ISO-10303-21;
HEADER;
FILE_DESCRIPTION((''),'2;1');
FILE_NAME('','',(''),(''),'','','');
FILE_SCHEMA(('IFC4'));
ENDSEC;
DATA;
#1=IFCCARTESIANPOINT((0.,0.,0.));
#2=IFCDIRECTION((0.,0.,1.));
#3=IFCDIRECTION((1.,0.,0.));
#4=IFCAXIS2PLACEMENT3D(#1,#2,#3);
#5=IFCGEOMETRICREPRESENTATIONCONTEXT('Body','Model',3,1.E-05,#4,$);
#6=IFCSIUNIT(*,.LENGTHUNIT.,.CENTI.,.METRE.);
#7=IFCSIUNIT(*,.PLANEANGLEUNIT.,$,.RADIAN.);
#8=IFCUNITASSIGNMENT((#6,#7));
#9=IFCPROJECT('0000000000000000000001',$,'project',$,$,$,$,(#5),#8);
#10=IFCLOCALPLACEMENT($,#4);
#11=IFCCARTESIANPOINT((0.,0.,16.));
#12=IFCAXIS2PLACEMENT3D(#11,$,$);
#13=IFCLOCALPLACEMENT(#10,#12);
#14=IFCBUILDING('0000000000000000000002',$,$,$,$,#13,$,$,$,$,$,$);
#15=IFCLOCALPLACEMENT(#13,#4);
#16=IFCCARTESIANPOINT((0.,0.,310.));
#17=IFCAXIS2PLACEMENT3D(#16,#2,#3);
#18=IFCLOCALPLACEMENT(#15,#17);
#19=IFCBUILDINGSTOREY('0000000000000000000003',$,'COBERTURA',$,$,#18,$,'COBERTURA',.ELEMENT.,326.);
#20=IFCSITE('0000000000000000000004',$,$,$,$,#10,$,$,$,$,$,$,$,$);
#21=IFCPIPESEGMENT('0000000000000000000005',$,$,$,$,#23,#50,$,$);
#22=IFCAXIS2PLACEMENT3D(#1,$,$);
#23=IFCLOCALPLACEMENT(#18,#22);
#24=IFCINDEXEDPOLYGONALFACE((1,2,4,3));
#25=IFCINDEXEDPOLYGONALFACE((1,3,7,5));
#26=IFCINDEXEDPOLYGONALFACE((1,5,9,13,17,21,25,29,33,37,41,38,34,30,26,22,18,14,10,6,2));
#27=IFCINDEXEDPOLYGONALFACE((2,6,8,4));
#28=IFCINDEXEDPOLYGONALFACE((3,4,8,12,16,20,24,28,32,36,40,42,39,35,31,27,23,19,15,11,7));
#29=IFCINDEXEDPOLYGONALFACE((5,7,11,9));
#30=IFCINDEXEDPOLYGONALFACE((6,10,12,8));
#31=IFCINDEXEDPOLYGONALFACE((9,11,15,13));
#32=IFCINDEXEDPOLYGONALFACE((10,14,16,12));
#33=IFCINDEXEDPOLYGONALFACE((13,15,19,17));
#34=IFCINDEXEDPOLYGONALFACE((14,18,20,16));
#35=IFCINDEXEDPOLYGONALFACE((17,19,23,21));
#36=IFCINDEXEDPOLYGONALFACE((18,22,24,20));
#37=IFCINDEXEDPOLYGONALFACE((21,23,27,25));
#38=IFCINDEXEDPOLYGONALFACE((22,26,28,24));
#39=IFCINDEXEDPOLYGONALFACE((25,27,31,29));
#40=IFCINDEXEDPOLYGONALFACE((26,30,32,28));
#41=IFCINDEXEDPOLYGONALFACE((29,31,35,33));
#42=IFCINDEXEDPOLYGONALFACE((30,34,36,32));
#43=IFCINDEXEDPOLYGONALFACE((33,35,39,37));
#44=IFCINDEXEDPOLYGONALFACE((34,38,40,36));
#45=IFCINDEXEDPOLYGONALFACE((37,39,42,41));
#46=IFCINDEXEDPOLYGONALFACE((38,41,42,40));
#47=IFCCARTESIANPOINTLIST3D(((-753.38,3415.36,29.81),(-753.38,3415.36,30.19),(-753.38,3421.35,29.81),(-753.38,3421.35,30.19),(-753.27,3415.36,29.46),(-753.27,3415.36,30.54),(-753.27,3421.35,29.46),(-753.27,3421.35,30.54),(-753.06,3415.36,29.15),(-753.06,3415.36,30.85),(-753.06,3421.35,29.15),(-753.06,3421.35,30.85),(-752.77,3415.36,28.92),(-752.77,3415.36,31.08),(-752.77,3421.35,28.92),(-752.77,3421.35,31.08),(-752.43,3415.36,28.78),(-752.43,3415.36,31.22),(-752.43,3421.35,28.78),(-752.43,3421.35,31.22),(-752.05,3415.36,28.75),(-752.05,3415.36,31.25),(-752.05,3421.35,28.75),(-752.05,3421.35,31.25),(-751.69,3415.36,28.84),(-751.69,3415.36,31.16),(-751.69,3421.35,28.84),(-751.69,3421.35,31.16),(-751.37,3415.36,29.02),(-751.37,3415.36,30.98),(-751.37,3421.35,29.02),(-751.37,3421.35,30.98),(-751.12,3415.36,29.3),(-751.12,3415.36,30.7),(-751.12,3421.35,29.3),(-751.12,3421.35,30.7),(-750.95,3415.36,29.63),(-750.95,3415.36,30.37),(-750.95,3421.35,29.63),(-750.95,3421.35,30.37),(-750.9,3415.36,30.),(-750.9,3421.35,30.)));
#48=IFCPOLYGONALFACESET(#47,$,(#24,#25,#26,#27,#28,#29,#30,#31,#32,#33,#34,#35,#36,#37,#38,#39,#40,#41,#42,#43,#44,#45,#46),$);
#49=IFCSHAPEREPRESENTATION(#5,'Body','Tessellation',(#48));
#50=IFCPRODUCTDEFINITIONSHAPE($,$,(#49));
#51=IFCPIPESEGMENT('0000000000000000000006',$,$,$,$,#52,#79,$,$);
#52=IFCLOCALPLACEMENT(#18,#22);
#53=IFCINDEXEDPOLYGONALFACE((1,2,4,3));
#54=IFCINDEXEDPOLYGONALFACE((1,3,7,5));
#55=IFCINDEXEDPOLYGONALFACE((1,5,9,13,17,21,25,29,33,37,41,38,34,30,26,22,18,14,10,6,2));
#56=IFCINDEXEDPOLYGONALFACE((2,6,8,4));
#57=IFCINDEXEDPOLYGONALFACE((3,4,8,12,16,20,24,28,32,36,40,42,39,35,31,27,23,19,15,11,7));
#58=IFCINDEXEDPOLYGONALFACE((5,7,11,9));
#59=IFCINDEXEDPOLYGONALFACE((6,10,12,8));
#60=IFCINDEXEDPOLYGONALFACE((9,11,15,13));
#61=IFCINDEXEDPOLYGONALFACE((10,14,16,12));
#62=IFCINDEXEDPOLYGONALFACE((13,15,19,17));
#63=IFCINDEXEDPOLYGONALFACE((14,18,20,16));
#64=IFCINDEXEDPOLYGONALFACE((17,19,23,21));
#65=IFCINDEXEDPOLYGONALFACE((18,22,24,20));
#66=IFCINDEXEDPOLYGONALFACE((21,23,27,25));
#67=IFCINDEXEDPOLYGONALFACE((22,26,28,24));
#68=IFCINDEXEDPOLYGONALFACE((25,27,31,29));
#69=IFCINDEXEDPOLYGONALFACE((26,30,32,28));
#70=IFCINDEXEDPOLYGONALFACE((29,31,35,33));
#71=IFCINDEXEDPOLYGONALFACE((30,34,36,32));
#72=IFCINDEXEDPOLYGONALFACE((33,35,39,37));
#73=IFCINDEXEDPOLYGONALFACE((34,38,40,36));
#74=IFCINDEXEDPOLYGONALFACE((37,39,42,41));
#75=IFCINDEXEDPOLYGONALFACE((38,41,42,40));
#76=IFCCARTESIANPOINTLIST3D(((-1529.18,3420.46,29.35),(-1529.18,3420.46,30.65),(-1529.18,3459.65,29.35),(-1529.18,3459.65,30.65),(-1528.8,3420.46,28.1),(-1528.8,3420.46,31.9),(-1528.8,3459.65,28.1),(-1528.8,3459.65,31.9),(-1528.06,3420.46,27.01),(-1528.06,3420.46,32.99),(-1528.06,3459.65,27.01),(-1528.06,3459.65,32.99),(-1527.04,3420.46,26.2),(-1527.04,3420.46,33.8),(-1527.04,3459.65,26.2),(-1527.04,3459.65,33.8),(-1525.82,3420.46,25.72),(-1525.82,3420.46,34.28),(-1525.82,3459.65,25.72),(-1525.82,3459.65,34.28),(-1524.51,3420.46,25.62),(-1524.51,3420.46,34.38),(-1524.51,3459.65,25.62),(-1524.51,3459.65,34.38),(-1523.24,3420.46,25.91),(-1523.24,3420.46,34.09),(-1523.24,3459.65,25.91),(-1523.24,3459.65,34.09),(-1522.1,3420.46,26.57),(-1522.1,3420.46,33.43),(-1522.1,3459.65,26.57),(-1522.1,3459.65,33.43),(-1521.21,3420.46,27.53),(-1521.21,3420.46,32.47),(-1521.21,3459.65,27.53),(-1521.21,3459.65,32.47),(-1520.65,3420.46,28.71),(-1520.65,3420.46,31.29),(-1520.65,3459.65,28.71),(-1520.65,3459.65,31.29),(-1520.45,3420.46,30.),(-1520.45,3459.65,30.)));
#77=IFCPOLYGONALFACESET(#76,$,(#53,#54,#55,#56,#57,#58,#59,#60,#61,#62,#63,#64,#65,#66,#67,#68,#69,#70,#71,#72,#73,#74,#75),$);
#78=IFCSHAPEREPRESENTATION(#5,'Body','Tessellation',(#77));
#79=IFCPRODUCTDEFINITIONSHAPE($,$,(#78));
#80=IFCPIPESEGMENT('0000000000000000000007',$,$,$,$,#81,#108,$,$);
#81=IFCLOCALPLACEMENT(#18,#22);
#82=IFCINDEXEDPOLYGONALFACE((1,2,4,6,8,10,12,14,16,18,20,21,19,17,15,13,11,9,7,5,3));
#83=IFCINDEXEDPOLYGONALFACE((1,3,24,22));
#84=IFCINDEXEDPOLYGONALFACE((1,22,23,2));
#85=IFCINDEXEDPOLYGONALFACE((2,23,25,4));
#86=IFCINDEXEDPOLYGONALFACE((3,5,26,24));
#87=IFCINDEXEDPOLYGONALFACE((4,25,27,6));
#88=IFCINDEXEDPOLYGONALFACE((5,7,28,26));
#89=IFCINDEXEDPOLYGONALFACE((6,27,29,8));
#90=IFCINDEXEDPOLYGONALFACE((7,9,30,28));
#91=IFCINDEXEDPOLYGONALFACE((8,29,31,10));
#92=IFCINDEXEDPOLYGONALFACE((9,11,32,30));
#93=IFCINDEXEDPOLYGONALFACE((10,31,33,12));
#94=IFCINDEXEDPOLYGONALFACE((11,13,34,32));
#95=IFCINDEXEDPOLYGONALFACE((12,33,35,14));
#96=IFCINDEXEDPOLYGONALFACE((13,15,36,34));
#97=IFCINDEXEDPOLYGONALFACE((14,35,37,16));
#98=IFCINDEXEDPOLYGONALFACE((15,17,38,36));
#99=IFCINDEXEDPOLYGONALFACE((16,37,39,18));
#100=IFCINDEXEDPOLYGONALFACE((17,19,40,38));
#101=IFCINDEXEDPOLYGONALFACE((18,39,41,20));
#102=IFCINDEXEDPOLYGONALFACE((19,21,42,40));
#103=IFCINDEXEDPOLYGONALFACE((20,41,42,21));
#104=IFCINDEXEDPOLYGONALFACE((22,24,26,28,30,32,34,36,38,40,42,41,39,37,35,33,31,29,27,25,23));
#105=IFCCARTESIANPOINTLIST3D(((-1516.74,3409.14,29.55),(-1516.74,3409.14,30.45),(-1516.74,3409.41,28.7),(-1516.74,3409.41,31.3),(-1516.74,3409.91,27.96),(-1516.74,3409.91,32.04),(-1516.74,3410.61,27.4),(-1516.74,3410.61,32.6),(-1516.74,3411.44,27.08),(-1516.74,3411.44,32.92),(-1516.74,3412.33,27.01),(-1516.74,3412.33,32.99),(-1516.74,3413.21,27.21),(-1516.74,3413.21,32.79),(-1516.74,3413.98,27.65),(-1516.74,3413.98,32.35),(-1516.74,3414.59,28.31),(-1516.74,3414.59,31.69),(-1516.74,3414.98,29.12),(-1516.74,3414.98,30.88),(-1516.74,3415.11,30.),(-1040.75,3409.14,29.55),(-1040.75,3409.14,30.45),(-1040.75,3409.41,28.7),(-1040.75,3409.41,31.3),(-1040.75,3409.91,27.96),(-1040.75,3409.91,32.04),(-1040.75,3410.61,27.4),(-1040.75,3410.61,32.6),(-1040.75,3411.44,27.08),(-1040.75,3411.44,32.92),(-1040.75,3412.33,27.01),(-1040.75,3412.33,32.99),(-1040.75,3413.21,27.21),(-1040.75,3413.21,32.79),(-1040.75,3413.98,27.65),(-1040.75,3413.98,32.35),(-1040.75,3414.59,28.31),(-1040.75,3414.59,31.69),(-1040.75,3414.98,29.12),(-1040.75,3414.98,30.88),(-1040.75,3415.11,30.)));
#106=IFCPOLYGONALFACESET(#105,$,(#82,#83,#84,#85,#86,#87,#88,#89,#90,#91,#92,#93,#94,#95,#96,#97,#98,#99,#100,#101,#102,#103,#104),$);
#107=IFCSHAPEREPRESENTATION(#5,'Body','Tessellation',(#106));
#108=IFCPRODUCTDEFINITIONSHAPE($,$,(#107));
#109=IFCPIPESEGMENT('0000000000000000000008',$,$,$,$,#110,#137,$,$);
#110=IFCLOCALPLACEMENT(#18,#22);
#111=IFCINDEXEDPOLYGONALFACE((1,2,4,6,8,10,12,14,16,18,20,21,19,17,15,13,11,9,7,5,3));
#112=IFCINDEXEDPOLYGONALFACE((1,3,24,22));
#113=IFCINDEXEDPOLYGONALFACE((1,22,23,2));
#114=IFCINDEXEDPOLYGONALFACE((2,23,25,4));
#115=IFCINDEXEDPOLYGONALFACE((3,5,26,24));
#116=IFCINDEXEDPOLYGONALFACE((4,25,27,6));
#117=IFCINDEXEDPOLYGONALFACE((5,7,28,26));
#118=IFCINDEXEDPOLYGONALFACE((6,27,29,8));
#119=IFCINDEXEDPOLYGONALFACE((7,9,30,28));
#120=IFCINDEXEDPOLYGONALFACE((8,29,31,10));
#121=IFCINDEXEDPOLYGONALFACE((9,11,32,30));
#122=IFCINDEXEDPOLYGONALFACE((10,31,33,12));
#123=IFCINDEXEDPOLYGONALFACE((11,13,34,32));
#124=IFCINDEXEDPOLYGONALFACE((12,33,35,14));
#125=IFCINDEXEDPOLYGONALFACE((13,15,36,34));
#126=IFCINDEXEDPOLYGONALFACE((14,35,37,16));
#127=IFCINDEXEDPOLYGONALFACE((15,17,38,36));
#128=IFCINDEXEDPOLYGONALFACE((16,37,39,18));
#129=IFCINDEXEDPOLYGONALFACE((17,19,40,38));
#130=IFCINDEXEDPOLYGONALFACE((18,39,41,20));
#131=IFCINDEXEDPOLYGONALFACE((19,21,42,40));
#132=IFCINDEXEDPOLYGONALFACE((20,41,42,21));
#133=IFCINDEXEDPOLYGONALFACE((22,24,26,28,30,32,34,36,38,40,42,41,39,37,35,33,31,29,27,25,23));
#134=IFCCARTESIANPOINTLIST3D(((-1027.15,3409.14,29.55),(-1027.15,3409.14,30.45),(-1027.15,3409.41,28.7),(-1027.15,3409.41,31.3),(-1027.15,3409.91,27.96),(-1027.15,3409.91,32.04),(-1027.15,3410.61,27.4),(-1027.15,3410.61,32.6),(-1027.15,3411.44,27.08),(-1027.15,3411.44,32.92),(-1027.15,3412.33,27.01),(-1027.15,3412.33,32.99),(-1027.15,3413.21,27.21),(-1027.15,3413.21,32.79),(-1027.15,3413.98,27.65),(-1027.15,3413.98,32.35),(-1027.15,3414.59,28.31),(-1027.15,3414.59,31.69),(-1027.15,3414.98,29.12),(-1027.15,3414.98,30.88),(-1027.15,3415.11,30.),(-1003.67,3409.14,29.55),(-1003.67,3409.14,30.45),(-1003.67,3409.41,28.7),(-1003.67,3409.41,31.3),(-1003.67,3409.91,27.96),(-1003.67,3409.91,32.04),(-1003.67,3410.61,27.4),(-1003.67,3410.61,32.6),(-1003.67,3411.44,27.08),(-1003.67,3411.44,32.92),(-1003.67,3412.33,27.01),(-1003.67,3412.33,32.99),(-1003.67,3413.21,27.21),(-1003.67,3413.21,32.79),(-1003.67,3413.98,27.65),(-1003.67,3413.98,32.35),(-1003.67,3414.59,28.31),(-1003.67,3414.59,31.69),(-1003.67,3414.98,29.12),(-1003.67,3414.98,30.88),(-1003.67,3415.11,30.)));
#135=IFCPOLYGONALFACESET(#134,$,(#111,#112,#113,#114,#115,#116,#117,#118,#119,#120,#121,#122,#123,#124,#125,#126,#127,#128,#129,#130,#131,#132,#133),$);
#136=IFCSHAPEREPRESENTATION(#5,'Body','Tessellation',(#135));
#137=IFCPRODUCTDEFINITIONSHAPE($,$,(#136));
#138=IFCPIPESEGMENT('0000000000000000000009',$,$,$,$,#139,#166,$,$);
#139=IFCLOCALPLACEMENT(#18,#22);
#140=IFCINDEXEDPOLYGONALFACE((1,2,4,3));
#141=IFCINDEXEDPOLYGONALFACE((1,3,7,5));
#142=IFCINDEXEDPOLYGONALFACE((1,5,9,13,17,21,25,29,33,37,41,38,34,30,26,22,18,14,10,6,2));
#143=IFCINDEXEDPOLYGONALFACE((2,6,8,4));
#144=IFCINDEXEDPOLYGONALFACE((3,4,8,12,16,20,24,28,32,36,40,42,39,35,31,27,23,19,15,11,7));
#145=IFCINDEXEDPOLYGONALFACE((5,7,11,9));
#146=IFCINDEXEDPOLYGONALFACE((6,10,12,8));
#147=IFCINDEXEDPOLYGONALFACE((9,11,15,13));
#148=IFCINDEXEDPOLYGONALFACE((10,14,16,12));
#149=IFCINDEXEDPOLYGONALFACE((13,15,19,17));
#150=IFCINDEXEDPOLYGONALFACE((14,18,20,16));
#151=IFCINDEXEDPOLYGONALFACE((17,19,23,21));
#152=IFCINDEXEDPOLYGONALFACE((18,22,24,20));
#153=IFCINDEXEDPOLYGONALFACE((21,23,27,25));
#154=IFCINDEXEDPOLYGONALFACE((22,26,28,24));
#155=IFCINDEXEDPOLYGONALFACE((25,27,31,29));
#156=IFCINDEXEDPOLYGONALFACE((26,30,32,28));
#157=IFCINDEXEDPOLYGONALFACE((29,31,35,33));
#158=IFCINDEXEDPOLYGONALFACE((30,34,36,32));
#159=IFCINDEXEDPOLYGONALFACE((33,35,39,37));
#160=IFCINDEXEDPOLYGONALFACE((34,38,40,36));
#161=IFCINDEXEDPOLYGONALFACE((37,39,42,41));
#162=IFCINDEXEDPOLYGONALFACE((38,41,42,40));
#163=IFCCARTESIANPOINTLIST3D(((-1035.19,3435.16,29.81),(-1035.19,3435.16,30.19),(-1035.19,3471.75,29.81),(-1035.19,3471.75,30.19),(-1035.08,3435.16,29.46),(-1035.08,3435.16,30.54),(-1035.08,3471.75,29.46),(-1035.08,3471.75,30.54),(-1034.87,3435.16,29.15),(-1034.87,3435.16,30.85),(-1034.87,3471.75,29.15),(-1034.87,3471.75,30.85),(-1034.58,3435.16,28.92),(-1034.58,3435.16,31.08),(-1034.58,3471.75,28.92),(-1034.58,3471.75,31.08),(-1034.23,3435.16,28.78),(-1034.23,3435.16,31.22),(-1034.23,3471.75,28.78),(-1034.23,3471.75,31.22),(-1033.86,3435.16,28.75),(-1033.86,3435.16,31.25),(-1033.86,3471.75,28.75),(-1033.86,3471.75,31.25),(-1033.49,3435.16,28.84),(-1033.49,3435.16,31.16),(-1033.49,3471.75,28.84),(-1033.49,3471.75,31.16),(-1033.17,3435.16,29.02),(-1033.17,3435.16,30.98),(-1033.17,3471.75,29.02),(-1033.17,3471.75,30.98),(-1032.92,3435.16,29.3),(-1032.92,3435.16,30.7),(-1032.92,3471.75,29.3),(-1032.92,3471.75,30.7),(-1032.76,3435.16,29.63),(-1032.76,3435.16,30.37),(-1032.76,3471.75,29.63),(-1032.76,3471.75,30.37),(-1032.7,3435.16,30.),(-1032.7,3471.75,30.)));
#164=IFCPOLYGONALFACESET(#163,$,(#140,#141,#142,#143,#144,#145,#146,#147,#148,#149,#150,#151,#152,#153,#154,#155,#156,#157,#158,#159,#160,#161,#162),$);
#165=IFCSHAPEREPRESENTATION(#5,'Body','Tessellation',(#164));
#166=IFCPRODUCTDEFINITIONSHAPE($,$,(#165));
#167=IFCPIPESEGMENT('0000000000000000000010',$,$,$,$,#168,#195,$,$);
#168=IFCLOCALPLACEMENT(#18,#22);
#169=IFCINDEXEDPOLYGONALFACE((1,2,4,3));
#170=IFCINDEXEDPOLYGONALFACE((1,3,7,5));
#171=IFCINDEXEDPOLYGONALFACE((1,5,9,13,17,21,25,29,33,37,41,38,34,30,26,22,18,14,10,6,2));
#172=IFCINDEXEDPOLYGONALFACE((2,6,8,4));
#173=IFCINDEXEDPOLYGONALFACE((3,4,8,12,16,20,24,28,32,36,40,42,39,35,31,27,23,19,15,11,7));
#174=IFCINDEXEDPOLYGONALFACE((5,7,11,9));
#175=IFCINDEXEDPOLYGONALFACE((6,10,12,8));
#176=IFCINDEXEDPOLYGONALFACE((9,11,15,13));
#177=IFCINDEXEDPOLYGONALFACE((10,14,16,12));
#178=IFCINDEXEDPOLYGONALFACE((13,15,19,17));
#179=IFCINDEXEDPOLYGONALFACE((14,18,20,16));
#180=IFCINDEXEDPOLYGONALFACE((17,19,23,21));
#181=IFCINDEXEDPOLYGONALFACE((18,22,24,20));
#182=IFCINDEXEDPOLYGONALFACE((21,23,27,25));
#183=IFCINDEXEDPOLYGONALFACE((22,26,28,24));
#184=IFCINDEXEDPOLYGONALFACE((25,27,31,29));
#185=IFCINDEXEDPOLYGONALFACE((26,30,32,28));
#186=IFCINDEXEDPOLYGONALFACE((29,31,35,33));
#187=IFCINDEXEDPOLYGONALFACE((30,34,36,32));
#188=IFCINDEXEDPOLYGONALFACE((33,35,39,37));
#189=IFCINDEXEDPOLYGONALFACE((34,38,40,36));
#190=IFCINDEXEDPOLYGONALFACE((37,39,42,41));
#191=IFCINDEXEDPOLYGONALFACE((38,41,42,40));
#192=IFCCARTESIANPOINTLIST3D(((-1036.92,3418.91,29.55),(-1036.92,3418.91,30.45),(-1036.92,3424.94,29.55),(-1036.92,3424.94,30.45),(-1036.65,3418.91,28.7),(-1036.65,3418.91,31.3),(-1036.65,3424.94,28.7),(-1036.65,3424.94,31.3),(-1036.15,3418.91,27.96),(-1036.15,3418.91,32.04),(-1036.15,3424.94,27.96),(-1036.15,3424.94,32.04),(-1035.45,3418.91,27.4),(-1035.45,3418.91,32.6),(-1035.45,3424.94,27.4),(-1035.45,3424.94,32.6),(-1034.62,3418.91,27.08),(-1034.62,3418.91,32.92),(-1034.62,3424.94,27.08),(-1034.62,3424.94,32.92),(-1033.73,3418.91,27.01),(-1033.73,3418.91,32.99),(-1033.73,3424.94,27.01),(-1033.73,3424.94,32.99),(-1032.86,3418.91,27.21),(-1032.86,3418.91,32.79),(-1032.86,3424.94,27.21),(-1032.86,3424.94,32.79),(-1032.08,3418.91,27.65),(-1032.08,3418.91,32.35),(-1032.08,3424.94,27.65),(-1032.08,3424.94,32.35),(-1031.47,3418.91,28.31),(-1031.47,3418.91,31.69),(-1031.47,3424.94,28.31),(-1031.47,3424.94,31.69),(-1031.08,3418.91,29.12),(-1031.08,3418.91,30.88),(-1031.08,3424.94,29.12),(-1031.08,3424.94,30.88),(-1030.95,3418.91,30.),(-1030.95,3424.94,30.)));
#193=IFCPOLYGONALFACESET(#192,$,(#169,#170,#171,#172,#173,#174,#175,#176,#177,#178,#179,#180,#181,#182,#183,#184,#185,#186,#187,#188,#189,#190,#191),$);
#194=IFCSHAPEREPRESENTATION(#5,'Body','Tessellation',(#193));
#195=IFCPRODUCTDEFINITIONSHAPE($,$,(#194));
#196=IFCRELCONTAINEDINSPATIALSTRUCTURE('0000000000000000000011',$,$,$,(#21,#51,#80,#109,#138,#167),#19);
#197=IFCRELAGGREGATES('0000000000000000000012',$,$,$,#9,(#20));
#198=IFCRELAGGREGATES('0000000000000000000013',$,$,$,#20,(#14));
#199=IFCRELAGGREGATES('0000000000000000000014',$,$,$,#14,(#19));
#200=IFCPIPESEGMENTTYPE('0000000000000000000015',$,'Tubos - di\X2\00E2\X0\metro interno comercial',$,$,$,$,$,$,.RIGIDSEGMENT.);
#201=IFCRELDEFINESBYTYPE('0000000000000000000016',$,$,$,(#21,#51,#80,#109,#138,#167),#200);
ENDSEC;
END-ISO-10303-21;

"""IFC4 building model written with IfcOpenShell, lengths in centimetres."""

from ifc_helpers import new_model, si_unit, frame, origin_with_axes, origin_2d_with_axis, place, context, project, spatial, circle, extrude, type_object, element, save


model = new_model("IFC4")

# Units and contexts
model_context = context("Model", 3, precision=1e-05, world=origin_with_axes(), identifier="Body")
ifc_project = project(units=[si_unit("LENGTHUNIT", "METRE", prefix="CENTI"), si_unit("PLANEANGLEUNIT", "RADIAN")], contexts=[model_context])

# Site, building, storey
site_placement = place(None, origin_with_axes())
site = spatial("IfcSite", under=ifc_project, at=site_placement)
building_placement = place(site_placement, frame((0.0, 0.0, 16.0)))
building = spatial("IfcBuilding", under=site, at=building_placement)
placement = place(building_placement, origin_with_axes())
storey_placement = place(placement, frame((0.0, 0.0, 310.0), z_axis=(0.0, 0.0, 1.0), x_axis=(1.0, 0.0, 0.0)))
storey = spatial("IfcBuildingStorey", under=building, at=storey_placement, Name="COBERTURA", LongName="COBERTURA", CompositionType="ELEMENT", Elevation=326.0)

# Pipe segments
pipe_segment_type = type_object("IfcPipeSegmentType", Name="Tubos - diâmetro interno comercial", PredefinedType="RIGIDSEGMENT")
pipe_segment_1_placement = place(storey_placement, frame((-752.15, 3418.35, 31.25), z_axis=(0.0, 0.0, 1.0), x_axis=(1.0, 0.0, 0.0)))
element("IfcPipeSegment", 1, at=pipe_segment_1_placement, inside=storey, type_object=pipe_segment_type, context=model_context, shape_type="SolidModel", body=[
    extrude(circle(Radius=1.25, at=origin_2d_with_axis()), frame((0.0, -2.99, -1.25), z_axis=(0.0, 1.0, 0.0), x_axis=(1.0, 0.0, 0.0)), (0.0, 0.0, 1.0), 5.99),
])
pipe_segment_2_placement = place(storey_placement, frame((-1524.84, 3440.05, 34.39), z_axis=(0.0, 0.0, 1.0), x_axis=(1.0, 0.0, 0.0)))
element("IfcPipeSegment", 2, at=pipe_segment_2_placement, inside=storey, type_object=pipe_segment_type, context=model_context, shape_type="SolidModel", body=[
    extrude(circle(Radius=4.39, at=origin_2d_with_axis()), frame((0.0, -19.59, -4.39), z_axis=(0.0, 1.0, 0.0), x_axis=(1.0, 0.0, 0.0)), (0.0, 0.0, 1.0), 39.19),
])
pipe_segment_3_placement = place(storey_placement, frame((-1278.75, 3412.11, 33.0), z_axis=(0.0, 0.0, 1.0), x_axis=(1.0, 0.0, 0.0)))
element("IfcPipeSegment", 3, at=pipe_segment_3_placement, inside=storey, type_object=pipe_segment_type, context=model_context, shape_type="SolidModel", body=[
    extrude(circle(Radius=3.0, at=origin_2d_with_axis()), frame((-238.0, 0.0, -3.0), z_axis=(1.0, 0.0, 0.0), x_axis=(0.0, 1.0, 0.0)), (0.0, 0.0, 1.0), 475.99),
])
pipe_segment_4_placement = place(storey_placement, frame((-1015.41, 3412.11, 33.0), z_axis=(0.0, 0.0, 1.0), x_axis=(1.0, 0.0, 0.0)))
element("IfcPipeSegment", 4, at=pipe_segment_4_placement, inside=storey, type_object=pipe_segment_type, context=model_context, shape_type="SolidModel", body=[
    extrude(circle(Radius=3.0, at=origin_2d_with_axis()), frame((-11.74, 0.0, -3.0), z_axis=(1.0, 0.0, 0.0), x_axis=(0.0, 1.0, 0.0)), (0.0, 0.0, 1.0), 23.48),
])
pipe_segment_5_placement = place(storey_placement, frame((-1033.95, 3453.45, 31.25), z_axis=(0.0, 0.0, 1.0), x_axis=(1.0, 0.0, 0.0)))
element("IfcPipeSegment", 5, at=pipe_segment_5_placement, inside=storey, type_object=pipe_segment_type, context=model_context, shape_type="SolidModel", body=[
    extrude(circle(Radius=1.25, at=origin_2d_with_axis()), frame((0.0, -18.29, -1.25), z_axis=(0.0, 1.0, 0.0), x_axis=(1.0, 0.0, 0.0)), (0.0, 0.0, 1.0), 36.58),
])
pipe_segment_6_placement = place(storey_placement, frame((-1033.95, 3421.93, 33.0), z_axis=(0.0, 0.0, 1.0), x_axis=(1.0, 0.0, 0.0)))
element("IfcPipeSegment", 6, at=pipe_segment_6_placement, inside=storey, type_object=pipe_segment_type, context=model_context, shape_type="SolidModel", body=[
    extrude(circle(Radius=3.0, at=origin_2d_with_axis()), frame((0.0, -3.02, -3.0), z_axis=(0.0, 1.0, 0.0), x_axis=(1.0, 0.0, 0.0)), (0.0, 0.0, 1.0), 6.03),
])

save(model, "model.ifc")
